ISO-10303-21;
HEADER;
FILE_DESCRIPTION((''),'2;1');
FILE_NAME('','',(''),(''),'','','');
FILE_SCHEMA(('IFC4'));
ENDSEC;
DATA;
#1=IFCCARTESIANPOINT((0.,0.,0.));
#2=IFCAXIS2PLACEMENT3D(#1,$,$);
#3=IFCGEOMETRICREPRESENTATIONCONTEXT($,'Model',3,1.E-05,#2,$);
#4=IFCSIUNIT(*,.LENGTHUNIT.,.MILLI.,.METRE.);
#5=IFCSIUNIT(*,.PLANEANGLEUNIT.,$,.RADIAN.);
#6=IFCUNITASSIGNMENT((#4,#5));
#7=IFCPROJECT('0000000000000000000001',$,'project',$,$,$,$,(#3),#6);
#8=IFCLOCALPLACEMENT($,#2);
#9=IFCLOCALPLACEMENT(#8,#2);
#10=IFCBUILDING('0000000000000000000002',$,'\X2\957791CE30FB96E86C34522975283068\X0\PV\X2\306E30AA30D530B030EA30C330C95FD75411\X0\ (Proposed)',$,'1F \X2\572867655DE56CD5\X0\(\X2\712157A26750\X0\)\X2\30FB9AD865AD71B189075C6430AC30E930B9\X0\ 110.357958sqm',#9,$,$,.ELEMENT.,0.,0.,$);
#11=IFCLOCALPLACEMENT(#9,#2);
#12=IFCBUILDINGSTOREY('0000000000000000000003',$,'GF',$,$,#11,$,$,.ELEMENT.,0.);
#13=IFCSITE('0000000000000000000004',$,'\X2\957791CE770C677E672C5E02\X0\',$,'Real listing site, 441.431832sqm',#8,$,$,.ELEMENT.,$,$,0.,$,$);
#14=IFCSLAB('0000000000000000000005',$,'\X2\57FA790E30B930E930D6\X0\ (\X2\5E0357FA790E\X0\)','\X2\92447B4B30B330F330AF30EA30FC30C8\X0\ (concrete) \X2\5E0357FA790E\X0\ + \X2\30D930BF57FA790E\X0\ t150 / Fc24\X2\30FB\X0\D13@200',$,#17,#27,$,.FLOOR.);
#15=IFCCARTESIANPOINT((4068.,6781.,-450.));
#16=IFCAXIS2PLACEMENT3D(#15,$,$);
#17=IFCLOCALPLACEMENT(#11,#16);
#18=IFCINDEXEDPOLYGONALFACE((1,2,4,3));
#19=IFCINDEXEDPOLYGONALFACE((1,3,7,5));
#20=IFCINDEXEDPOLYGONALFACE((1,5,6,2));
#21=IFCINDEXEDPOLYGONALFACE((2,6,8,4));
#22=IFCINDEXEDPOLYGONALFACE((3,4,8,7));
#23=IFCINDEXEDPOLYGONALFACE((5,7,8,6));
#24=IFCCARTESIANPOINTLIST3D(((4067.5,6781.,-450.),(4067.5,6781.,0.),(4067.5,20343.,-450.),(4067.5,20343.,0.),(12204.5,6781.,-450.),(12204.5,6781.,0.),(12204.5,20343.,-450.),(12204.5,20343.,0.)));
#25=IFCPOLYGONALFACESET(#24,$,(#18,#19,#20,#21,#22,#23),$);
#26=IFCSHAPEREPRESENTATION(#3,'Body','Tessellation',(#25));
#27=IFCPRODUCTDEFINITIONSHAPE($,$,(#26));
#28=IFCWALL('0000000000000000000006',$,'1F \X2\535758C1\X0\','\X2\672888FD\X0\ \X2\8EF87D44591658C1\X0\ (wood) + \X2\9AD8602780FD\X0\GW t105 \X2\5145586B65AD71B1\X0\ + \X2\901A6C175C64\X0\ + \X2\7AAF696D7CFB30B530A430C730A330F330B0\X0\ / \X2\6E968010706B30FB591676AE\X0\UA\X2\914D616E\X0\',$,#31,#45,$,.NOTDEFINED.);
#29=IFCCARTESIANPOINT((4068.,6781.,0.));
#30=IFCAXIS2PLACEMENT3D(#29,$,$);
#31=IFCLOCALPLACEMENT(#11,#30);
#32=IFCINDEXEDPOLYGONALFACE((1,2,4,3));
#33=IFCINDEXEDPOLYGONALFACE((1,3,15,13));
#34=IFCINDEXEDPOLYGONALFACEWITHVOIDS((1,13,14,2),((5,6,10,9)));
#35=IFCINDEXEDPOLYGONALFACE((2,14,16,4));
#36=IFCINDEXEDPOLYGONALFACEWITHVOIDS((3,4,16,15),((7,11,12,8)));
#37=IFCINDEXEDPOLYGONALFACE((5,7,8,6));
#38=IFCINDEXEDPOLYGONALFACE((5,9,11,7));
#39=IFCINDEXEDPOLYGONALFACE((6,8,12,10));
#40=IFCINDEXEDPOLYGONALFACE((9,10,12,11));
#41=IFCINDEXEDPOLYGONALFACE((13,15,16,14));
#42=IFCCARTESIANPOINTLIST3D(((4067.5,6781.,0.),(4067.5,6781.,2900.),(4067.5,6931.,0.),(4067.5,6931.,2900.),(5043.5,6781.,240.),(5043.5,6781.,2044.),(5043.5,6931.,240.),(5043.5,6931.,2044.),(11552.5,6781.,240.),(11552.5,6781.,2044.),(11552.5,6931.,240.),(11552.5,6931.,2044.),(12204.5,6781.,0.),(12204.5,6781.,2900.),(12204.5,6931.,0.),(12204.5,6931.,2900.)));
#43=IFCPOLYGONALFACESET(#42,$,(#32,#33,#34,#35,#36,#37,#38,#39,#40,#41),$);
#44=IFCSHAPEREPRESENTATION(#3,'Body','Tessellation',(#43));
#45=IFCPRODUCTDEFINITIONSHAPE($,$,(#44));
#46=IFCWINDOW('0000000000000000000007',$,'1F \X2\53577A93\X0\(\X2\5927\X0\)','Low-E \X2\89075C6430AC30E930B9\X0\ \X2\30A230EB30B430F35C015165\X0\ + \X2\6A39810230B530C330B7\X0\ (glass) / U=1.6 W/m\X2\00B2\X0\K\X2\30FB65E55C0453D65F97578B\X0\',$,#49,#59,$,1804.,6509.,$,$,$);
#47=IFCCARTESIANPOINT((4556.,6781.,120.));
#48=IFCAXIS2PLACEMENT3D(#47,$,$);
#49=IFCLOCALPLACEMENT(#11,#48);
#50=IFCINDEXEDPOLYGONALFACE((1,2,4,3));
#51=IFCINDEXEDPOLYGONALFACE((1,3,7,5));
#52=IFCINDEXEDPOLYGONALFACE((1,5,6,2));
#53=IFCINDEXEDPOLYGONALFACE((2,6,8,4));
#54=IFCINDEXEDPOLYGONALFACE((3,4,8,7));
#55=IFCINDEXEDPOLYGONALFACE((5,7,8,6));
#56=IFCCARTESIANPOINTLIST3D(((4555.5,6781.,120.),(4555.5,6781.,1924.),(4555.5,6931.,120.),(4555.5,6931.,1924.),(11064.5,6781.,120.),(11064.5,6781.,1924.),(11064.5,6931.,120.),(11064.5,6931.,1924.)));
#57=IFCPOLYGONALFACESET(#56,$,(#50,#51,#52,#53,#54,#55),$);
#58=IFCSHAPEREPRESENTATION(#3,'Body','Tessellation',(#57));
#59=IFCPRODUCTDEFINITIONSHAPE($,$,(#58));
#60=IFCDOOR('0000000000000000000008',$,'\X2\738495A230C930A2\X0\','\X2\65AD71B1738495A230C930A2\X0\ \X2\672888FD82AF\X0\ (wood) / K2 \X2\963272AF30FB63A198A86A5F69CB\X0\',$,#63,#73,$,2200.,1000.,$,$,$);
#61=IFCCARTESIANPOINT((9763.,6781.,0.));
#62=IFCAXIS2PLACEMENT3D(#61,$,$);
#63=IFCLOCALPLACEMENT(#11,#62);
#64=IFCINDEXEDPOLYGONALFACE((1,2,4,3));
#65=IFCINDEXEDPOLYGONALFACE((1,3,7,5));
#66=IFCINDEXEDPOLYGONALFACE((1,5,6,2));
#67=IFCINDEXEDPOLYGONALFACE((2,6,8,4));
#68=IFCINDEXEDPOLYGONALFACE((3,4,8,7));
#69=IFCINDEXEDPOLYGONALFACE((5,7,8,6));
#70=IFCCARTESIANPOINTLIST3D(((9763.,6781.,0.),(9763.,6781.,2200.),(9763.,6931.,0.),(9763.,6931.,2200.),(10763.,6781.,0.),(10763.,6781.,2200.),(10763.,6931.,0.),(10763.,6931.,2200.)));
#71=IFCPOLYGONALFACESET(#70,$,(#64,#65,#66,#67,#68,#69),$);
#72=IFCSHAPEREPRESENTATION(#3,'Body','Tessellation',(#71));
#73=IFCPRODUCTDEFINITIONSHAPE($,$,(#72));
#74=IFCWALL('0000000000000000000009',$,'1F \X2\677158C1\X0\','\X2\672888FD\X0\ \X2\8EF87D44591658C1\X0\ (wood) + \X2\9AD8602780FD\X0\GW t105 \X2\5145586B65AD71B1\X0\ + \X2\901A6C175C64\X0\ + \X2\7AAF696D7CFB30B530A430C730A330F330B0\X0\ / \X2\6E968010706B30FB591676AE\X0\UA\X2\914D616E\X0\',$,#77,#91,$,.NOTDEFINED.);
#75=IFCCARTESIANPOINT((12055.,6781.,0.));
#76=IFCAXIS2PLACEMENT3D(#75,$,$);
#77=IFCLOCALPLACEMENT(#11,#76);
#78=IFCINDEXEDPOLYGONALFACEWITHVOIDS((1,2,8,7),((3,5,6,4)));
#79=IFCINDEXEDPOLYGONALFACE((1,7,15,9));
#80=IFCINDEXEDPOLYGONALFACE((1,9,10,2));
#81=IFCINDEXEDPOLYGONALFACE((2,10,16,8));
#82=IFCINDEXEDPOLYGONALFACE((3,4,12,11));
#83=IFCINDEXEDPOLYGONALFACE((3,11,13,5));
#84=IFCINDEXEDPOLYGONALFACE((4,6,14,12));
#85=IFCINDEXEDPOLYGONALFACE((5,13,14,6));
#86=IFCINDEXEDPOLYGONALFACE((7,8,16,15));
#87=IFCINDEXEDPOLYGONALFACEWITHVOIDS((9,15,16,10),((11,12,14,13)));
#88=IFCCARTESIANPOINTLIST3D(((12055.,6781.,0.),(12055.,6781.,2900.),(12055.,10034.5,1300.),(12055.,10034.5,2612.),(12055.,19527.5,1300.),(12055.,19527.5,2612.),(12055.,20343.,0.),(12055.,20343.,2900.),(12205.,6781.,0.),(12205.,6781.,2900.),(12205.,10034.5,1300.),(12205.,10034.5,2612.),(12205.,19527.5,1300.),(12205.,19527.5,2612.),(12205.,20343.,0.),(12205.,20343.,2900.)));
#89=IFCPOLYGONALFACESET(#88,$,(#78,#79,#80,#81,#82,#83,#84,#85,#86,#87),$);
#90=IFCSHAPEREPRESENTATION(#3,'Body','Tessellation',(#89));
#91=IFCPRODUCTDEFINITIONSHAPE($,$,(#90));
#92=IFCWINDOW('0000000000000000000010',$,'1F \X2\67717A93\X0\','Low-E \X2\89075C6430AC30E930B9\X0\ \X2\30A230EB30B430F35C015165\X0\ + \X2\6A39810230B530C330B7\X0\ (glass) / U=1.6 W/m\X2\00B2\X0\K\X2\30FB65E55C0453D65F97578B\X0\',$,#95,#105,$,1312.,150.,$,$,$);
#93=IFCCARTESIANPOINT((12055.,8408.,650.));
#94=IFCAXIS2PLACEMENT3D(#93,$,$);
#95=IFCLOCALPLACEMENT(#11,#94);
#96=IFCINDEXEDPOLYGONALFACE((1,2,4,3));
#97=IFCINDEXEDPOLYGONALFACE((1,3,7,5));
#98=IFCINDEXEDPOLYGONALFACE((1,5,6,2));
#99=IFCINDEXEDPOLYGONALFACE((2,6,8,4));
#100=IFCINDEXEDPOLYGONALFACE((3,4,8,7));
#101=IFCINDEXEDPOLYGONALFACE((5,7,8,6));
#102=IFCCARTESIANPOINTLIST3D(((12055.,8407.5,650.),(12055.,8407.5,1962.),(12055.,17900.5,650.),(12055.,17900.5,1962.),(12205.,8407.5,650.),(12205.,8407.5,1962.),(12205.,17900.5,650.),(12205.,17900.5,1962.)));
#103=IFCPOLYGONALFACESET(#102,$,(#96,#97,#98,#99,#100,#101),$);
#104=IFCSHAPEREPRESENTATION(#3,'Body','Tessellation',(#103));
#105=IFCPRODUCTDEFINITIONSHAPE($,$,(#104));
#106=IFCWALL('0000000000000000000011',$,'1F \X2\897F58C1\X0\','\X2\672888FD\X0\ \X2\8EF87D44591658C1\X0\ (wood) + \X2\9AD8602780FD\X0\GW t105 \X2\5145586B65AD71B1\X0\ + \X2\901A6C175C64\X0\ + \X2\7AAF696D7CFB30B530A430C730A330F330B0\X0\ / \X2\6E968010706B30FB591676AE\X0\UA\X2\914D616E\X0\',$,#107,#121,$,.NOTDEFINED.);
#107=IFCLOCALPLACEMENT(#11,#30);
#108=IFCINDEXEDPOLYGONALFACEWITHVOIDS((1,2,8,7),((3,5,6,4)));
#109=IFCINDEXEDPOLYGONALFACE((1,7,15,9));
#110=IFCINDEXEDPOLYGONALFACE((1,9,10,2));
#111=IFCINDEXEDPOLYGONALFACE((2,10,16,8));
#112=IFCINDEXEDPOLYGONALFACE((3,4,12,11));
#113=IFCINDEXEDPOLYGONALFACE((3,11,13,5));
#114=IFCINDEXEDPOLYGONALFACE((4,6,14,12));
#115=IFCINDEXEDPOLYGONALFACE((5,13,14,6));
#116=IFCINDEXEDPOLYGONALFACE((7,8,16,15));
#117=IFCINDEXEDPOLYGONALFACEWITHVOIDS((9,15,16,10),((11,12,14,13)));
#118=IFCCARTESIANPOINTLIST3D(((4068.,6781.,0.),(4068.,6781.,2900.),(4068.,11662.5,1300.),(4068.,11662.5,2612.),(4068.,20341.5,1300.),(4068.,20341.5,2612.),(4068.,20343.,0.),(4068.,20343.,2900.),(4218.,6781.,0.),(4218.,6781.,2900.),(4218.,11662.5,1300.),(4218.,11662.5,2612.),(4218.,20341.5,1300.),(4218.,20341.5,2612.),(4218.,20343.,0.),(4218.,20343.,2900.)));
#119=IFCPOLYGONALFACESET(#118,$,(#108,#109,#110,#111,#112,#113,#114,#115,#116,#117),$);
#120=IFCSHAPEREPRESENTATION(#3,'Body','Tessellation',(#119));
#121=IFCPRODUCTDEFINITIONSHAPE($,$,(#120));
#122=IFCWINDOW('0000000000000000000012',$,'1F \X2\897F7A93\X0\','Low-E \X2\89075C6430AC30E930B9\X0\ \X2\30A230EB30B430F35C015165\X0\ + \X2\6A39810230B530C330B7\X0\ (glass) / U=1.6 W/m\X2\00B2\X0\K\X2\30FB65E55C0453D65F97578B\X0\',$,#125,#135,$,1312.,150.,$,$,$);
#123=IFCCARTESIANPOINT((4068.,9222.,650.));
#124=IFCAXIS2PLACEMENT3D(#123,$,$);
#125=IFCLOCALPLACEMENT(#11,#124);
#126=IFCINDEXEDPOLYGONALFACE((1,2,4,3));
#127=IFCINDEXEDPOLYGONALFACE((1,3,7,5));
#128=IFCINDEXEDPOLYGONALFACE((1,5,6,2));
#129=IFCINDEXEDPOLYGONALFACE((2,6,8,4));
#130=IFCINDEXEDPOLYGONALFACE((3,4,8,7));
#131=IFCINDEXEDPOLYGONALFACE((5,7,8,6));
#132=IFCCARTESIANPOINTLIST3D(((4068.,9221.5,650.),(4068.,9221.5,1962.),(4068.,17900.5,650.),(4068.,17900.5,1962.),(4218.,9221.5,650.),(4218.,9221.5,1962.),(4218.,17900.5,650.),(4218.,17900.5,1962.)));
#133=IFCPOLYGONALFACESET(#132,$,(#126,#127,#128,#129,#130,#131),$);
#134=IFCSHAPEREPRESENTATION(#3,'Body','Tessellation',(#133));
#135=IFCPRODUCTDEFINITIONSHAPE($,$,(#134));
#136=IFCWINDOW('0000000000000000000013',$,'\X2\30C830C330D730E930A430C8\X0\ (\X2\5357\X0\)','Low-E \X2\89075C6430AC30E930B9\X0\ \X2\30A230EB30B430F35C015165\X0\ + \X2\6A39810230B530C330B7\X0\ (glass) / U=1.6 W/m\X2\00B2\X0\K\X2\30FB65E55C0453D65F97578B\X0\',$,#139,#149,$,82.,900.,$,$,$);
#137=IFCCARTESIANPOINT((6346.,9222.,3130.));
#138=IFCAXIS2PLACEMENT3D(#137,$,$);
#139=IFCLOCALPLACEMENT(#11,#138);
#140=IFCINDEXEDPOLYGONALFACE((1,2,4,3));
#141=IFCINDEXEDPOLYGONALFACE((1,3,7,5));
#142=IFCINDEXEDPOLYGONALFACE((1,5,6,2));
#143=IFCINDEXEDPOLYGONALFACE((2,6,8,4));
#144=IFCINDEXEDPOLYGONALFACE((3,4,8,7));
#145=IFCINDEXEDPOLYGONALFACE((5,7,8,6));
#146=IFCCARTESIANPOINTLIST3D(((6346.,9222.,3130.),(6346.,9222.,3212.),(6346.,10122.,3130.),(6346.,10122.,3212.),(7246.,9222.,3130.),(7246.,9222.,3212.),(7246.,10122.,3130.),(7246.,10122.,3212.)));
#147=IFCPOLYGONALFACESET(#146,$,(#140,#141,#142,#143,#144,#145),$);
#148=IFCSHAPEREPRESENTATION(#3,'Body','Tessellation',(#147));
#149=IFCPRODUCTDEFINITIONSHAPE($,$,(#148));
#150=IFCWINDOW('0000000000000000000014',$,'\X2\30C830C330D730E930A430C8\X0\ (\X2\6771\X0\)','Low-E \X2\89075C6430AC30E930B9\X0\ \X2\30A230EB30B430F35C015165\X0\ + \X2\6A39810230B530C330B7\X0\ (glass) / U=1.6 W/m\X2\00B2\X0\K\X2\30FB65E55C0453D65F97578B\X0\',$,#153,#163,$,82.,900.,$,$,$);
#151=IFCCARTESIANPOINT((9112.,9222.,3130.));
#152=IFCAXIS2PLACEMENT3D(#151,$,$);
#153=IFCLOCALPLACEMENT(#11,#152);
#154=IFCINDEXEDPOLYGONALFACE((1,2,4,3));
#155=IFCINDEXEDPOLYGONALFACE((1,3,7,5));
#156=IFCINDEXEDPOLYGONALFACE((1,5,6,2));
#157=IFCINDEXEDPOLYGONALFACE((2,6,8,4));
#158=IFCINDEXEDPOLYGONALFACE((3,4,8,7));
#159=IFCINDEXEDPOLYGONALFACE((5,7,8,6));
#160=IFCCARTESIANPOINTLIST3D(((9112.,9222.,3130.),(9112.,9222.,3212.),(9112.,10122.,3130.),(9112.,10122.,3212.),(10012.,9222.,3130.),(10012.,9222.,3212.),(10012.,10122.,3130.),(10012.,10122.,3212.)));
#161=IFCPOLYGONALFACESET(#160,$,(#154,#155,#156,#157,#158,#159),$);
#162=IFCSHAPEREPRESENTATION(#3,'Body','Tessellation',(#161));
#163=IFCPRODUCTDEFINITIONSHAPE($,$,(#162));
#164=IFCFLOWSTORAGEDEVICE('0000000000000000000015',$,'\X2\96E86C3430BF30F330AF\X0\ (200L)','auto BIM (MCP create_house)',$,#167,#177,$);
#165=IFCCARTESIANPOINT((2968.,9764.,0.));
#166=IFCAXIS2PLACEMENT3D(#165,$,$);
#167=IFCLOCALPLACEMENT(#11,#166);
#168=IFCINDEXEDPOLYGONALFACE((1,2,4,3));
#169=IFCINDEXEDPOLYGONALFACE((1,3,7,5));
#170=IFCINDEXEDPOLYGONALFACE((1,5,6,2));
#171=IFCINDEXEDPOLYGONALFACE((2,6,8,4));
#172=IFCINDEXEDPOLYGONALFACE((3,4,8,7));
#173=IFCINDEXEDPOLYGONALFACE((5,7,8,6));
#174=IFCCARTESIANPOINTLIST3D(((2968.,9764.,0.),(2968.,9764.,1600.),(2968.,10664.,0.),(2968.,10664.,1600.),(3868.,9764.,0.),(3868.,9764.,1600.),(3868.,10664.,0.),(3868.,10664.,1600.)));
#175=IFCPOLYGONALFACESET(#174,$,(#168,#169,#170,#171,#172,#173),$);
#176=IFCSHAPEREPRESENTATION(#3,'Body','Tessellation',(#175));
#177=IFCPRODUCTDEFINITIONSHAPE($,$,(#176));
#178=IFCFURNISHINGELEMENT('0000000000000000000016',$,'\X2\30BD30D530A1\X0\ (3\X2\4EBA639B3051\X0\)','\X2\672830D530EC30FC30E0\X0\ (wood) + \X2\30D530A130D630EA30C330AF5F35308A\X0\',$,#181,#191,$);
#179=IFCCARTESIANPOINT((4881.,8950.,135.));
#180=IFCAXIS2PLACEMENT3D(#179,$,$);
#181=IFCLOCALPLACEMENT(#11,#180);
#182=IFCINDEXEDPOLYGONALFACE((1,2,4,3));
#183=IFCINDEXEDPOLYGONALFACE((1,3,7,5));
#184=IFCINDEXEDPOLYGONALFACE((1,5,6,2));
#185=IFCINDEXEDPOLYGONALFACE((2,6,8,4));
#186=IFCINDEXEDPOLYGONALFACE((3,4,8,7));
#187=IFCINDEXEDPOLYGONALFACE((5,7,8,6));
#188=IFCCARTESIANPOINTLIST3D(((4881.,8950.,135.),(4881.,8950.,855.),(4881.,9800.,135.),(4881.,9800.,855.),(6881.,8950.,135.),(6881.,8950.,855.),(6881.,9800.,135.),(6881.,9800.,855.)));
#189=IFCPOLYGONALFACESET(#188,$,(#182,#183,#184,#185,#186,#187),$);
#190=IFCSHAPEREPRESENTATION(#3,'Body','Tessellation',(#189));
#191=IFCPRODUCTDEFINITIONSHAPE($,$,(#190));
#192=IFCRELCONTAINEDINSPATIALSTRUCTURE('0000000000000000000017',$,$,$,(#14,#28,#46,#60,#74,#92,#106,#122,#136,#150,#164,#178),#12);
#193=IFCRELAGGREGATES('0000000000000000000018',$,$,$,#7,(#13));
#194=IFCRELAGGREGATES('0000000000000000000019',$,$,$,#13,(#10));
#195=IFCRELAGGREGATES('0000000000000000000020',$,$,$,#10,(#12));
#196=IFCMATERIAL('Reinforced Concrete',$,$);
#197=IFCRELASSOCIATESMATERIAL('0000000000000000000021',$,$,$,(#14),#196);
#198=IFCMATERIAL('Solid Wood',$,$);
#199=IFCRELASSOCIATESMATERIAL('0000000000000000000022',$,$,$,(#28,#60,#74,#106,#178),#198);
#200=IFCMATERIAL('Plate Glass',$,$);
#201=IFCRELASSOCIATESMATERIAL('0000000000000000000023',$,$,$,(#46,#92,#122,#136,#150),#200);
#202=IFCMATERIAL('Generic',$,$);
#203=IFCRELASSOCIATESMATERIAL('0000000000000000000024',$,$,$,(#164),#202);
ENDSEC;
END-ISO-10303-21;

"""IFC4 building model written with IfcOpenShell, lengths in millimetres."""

from ifc_helpers import new_model, si_unit, frame, frame_2d, origin, place, context, project, spatial, rectangle, extrude, material, element, fill, save


model = new_model("IFC4")

# Units and contexts
model_context = context("Model", 3, precision=1e-05, world=origin())
ifc_project = project(units=[si_unit("LENGTHUNIT", "METRE", prefix="MILLI"), si_unit("PLANEANGLEUNIT", "RADIAN")], contexts=[model_context])

# Site, building, storey
site_placement = place(None, origin())
site = spatial("IfcSite", under=ifc_project, at=site_placement, Name="長野県松本市", ObjectType="Real listing site, 441.431832sqm", CompositionType="ELEMENT", RefElevation=0.0)
building_placement = place(site_placement, origin())
building = spatial("IfcBuilding", under=site, at=building_placement, Name="長野・雨水利用とPVのオフグリッド志向 (Proposed)", ObjectType="1F 在来工法(無垢材)・高断熱複層ガラス 110.357958sqm", CompositionType="ELEMENT", ElevationOfRefHeight=0.0, ElevationOfTerrain=0.0)
storey_placement = place(building_placement, origin())
storey = spatial("IfcBuildingStorey", under=building, at=storey_placement, Name="GF", CompositionType="ELEMENT", Elevation=0.0)

# Slab
ifc_material_1 = material(Name="Reinforced Concrete")
slab_1_placement = place(storey_placement, frame((4068.0, 6781.0, -450.0)))
element("IfcSlab", 1, at=slab_1_placement, inside=storey, material=ifc_material_1, Name="基礎スラブ (布基礎)", Description="鉄筋コンクリート (concrete) 布基礎 + ベタ基礎 t150 / Fc24・D13@200", PredefinedType="FLOOR", context=model_context, shape_type="SweptSolid", body=[
    extrude(rectangle(XDim=8137.0, YDim=13562.0, at=frame_2d((4068.0, 6781.0))), frame((4068.0, 6781.0, -450.0)), (0.0, 0.0, 1.0), 450.0),
])
ifc_material_2 = material(Name="Solid Wood")

# Wall, openings, window, door
wall_1_placement = place(storey_placement, frame((4068.0, 6781.0, 0.0)))
wall_1 = element("IfcWall", 2, at=wall_1_placement, inside=storey, material=ifc_material_2, Name="1F 南壁", Description="木製 軸組外壁 (wood) + 高性能GW t105 充填断熱 + 通気層 + 窯業系サイディング / 準耐火・外皮UA配慮", PredefinedType="NOTDEFINED", context=model_context, shape_type="SweptSolid", body=[
    extrude(rectangle(XDim=8137.0, YDim=150.0, at=frame_2d((4068.0, 75.0))), frame((4068.0, 6781.0, 0.0)), (0.0, 0.0, 1.0), 2900.0),
])
opening_1_placement = place(storey_placement, frame((4556.0, 6781.0, 120.0)))
opening_1 = element("IfcOpeningElement", 3, at=opening_1_placement, cuts=wall_1, PredefinedType="NOTDEFINED", context=model_context, shape_type="SweptSolid", body=[
    extrude(rectangle(XDim=6509.0, YDim=150.0, at=frame_2d((3254.0, 75.0))), frame((4556.0, 6781.0, 120.0)), (0.0, 0.0, 1.0), 1804.0),
])
opening_2_placement = place(storey_placement, frame((9763.0, 6781.0, 0.0)))
opening_2 = element("IfcOpeningElement", 4, at=opening_2_placement, cuts=wall_1, PredefinedType="NOTDEFINED", context=model_context, shape_type="SweptSolid", body=[
    extrude(rectangle(XDim=1000.0, YDim=150.0, at=frame_2d((500.0, 75.0))), frame((9763.0, 6781.0, 0.0)), (0.0, 0.0, 1.0), 2200.0),
])
ifc_material_3 = material(Name="Plate Glass")
window_1_placement = place(storey_placement, frame((4556.0, 6781.0, 120.0)))
window_1 = element("IfcWindow", 5, at=window_1_placement, inside=storey, material=ifc_material_3, Name="1F 南窓(大)", Description="Low-E 複層ガラス アルゴン封入 + 樹脂サッシ (glass) / U=1.6 W/m²K・日射取得型", OverallHeight=1804.0, OverallWidth=6509.0, context=model_context, shape_type="SweptSolid", body=[
    extrude(rectangle(XDim=6509.0, YDim=150.0, at=frame_2d((3254.0, 75.0))), frame((4556.0, 6781.0, 120.0)), (0.0, 0.0, 1.0), 1804.0),
])
fill(opening_1, window_1)
door_placement = place(storey_placement, frame((9763.0, 6781.0, 0.0)))
door = element("IfcDoor", 6, at=door_placement, inside=storey, material=ifc_material_2, Name="玄関ドア", Description="断熱玄関ドア 木製芯 (wood) / K2 防犯・採風機構", OverallHeight=2200.0, OverallWidth=1000.0, context=model_context, shape_type="SweptSolid", body=[
    extrude(rectangle(XDim=1000.0, YDim=150.0, at=frame_2d((500.0, 75.0))), frame((9763.0, 6781.0, 0.0)), (0.0, 0.0, 1.0), 2200.0),
])
fill(opening_2, door)

# Walls, openings, windows
wall_2_placement = place(storey_placement, frame((12055.0, 6781.0, 0.0)))
wall_2 = element("IfcWall", 7, at=wall_2_placement, inside=storey, material=ifc_material_2, Name="1F 東壁", Description="木製 軸組外壁 (wood) + 高性能GW t105 充填断熱 + 通気層 + 窯業系サイディング / 準耐火・外皮UA配慮", PredefinedType="NOTDEFINED", context=model_context, shape_type="SweptSolid", body=[
    extrude(rectangle(XDim=150.0, YDim=13562.0, at=frame_2d((75.0, 6781.0))), frame((12055.0, 6781.0, 0.0)), (0.0, 0.0, 1.0), 2900.0),
])
opening_3_placement = place(storey_placement, frame((12055.0, 8408.0, 650.0)))
opening_3 = element("IfcOpeningElement", 8, at=opening_3_placement, cuts=wall_2, PredefinedType="NOTDEFINED", context=model_context, shape_type="SweptSolid", body=[
    extrude(rectangle(XDim=150.0, YDim=9493.0, at=frame_2d((75.0, 4746.0))), frame((12055.0, 8408.0, 650.0)), (0.0, 0.0, 1.0), 1312.0),
])
window_2_placement = place(storey_placement, frame((12055.0, 8408.0, 650.0)))
window_2 = element("IfcWindow", 9, at=window_2_placement, inside=storey, material=ifc_material_3, Name="1F 東窓", Description="Low-E 複層ガラス アルゴン封入 + 樹脂サッシ (glass) / U=1.6 W/m²K・日射取得型", OverallHeight=1312.0, OverallWidth=150.0, context=model_context, shape_type="SweptSolid", body=[
    extrude(rectangle(XDim=150.0, YDim=9493.0, at=frame_2d((75.0, 4746.0))), frame((12055.0, 8408.0, 650.0)), (0.0, 0.0, 1.0), 1312.0),
])
fill(opening_3, window_2)
wall_3_placement = place(storey_placement, frame((4068.0, 6781.0, 0.0)))
wall_3 = element("IfcWall", 10, at=wall_3_placement, inside=storey, material=ifc_material_2, Name="1F 西壁", Description="木製 軸組外壁 (wood) + 高性能GW t105 充填断熱 + 通気層 + 窯業系サイディング / 準耐火・外皮UA配慮", PredefinedType="NOTDEFINED", context=model_context, shape_type="SweptSolid", body=[
    extrude(rectangle(XDim=150.0, YDim=13562.0, at=frame_2d((75.0, 6781.0))), frame((4068.0, 6781.0, 0.0)), (0.0, 0.0, 1.0), 2900.0),
])
opening_4_placement = place(storey_placement, frame((4068.0, 9222.0, 650.0)))
opening_4 = element("IfcOpeningElement", 11, at=opening_4_placement, cuts=wall_3, PredefinedType="NOTDEFINED", context=model_context, shape_type="SweptSolid", body=[
    extrude(rectangle(XDim=150.0, YDim=8679.0, at=frame_2d((75.0, 4339.0))), frame((4068.0, 9222.0, 650.0)), (0.0, 0.0, 1.0), 1312.0),
])
window_3_placement = place(storey_placement, frame((4068.0, 9222.0, 650.0)))
window_3 = element("IfcWindow", 12, at=window_3_placement, inside=storey, material=ifc_material_3, Name="1F 西窓", Description="Low-E 複層ガラス アルゴン封入 + 樹脂サッシ (glass) / U=1.6 W/m²K・日射取得型", OverallHeight=1312.0, OverallWidth=150.0, context=model_context, shape_type="SweptSolid", body=[
    extrude(rectangle(XDim=150.0, YDim=8679.0, at=frame_2d((75.0, 4339.0))), frame((4068.0, 9222.0, 650.0)), (0.0, 0.0, 1.0), 1312.0),
])
fill(opening_4, window_3)

# Windows
window_4_placement = place(storey_placement, frame((6346.0, 9222.0, 3130.0)))
element("IfcWindow", 13, at=window_4_placement, inside=storey, material=ifc_material_3, Name="トップライト (南)", Description="Low-E 複層ガラス アルゴン封入 + 樹脂サッシ (glass) / U=1.6 W/m²K・日射取得型", OverallHeight=82.0, OverallWidth=900.0, context=model_context, shape_type="SweptSolid", body=[
    extrude(rectangle(XDim=900.0, YDim=900.0, at=frame_2d((450.0, 450.0))), frame((6346.0, 9222.0, 3130.0)), (0.0, 0.0, 1.0), 82.0),
])
window_5_placement = place(storey_placement, frame((9112.0, 9222.0, 3130.0)))
element("IfcWindow", 14, at=window_5_placement, inside=storey, material=ifc_material_3, Name="トップライト (東)", Description="Low-E 複層ガラス アルゴン封入 + 樹脂サッシ (glass) / U=1.6 W/m²K・日射取得型", OverallHeight=82.0, OverallWidth=900.0, context=model_context, shape_type="SweptSolid", body=[
    extrude(rectangle(XDim=900.0, YDim=900.0, at=frame_2d((450.0, 450.0))), frame((9112.0, 9222.0, 3130.0)), (0.0, 0.0, 1.0), 82.0),
])

# Shared definitions
ifc_material_4 = material(Name="Generic")

# Flow storage device
flow_storage_device_placement = place(storey_placement, frame((2968.0, 9764.0, 0.0)))
element("IfcFlowStorageDevice", 15, at=flow_storage_device_placement, inside=storey, material=ifc_material_4, Name="雨水タンク (200L)", Description="auto BIM (MCP create_house)", context=model_context, shape_type="SweptSolid", body=[
    extrude(rectangle(XDim=900.0, YDim=900.0, at=frame_2d((450.0, 450.0))), frame((2968.0, 9764.0, 0.0)), (0.0, 0.0, 1.0), 1600.0),
])

# Furnishing element
furnishing_1_placement = place(storey_placement, frame((4881.0, 8950.0, 135.0)))
element("IfcFurnishingElement", 16, at=furnishing_1_placement, inside=storey, material=ifc_material_2, Name="ソファ (3人掛け)", Description="木フレーム (wood) + ファブリック張り", context=model_context, shape_type="SweptSolid", body=[
    extrude(rectangle(XDim=2000.0, YDim=850.0, at=frame_2d((1000.0, 425.0))), frame((4881.0, 8950.0, 135.0)), (0.0, 0.0, 1.0), 720.0),
])

save(model, "model.ifc")
